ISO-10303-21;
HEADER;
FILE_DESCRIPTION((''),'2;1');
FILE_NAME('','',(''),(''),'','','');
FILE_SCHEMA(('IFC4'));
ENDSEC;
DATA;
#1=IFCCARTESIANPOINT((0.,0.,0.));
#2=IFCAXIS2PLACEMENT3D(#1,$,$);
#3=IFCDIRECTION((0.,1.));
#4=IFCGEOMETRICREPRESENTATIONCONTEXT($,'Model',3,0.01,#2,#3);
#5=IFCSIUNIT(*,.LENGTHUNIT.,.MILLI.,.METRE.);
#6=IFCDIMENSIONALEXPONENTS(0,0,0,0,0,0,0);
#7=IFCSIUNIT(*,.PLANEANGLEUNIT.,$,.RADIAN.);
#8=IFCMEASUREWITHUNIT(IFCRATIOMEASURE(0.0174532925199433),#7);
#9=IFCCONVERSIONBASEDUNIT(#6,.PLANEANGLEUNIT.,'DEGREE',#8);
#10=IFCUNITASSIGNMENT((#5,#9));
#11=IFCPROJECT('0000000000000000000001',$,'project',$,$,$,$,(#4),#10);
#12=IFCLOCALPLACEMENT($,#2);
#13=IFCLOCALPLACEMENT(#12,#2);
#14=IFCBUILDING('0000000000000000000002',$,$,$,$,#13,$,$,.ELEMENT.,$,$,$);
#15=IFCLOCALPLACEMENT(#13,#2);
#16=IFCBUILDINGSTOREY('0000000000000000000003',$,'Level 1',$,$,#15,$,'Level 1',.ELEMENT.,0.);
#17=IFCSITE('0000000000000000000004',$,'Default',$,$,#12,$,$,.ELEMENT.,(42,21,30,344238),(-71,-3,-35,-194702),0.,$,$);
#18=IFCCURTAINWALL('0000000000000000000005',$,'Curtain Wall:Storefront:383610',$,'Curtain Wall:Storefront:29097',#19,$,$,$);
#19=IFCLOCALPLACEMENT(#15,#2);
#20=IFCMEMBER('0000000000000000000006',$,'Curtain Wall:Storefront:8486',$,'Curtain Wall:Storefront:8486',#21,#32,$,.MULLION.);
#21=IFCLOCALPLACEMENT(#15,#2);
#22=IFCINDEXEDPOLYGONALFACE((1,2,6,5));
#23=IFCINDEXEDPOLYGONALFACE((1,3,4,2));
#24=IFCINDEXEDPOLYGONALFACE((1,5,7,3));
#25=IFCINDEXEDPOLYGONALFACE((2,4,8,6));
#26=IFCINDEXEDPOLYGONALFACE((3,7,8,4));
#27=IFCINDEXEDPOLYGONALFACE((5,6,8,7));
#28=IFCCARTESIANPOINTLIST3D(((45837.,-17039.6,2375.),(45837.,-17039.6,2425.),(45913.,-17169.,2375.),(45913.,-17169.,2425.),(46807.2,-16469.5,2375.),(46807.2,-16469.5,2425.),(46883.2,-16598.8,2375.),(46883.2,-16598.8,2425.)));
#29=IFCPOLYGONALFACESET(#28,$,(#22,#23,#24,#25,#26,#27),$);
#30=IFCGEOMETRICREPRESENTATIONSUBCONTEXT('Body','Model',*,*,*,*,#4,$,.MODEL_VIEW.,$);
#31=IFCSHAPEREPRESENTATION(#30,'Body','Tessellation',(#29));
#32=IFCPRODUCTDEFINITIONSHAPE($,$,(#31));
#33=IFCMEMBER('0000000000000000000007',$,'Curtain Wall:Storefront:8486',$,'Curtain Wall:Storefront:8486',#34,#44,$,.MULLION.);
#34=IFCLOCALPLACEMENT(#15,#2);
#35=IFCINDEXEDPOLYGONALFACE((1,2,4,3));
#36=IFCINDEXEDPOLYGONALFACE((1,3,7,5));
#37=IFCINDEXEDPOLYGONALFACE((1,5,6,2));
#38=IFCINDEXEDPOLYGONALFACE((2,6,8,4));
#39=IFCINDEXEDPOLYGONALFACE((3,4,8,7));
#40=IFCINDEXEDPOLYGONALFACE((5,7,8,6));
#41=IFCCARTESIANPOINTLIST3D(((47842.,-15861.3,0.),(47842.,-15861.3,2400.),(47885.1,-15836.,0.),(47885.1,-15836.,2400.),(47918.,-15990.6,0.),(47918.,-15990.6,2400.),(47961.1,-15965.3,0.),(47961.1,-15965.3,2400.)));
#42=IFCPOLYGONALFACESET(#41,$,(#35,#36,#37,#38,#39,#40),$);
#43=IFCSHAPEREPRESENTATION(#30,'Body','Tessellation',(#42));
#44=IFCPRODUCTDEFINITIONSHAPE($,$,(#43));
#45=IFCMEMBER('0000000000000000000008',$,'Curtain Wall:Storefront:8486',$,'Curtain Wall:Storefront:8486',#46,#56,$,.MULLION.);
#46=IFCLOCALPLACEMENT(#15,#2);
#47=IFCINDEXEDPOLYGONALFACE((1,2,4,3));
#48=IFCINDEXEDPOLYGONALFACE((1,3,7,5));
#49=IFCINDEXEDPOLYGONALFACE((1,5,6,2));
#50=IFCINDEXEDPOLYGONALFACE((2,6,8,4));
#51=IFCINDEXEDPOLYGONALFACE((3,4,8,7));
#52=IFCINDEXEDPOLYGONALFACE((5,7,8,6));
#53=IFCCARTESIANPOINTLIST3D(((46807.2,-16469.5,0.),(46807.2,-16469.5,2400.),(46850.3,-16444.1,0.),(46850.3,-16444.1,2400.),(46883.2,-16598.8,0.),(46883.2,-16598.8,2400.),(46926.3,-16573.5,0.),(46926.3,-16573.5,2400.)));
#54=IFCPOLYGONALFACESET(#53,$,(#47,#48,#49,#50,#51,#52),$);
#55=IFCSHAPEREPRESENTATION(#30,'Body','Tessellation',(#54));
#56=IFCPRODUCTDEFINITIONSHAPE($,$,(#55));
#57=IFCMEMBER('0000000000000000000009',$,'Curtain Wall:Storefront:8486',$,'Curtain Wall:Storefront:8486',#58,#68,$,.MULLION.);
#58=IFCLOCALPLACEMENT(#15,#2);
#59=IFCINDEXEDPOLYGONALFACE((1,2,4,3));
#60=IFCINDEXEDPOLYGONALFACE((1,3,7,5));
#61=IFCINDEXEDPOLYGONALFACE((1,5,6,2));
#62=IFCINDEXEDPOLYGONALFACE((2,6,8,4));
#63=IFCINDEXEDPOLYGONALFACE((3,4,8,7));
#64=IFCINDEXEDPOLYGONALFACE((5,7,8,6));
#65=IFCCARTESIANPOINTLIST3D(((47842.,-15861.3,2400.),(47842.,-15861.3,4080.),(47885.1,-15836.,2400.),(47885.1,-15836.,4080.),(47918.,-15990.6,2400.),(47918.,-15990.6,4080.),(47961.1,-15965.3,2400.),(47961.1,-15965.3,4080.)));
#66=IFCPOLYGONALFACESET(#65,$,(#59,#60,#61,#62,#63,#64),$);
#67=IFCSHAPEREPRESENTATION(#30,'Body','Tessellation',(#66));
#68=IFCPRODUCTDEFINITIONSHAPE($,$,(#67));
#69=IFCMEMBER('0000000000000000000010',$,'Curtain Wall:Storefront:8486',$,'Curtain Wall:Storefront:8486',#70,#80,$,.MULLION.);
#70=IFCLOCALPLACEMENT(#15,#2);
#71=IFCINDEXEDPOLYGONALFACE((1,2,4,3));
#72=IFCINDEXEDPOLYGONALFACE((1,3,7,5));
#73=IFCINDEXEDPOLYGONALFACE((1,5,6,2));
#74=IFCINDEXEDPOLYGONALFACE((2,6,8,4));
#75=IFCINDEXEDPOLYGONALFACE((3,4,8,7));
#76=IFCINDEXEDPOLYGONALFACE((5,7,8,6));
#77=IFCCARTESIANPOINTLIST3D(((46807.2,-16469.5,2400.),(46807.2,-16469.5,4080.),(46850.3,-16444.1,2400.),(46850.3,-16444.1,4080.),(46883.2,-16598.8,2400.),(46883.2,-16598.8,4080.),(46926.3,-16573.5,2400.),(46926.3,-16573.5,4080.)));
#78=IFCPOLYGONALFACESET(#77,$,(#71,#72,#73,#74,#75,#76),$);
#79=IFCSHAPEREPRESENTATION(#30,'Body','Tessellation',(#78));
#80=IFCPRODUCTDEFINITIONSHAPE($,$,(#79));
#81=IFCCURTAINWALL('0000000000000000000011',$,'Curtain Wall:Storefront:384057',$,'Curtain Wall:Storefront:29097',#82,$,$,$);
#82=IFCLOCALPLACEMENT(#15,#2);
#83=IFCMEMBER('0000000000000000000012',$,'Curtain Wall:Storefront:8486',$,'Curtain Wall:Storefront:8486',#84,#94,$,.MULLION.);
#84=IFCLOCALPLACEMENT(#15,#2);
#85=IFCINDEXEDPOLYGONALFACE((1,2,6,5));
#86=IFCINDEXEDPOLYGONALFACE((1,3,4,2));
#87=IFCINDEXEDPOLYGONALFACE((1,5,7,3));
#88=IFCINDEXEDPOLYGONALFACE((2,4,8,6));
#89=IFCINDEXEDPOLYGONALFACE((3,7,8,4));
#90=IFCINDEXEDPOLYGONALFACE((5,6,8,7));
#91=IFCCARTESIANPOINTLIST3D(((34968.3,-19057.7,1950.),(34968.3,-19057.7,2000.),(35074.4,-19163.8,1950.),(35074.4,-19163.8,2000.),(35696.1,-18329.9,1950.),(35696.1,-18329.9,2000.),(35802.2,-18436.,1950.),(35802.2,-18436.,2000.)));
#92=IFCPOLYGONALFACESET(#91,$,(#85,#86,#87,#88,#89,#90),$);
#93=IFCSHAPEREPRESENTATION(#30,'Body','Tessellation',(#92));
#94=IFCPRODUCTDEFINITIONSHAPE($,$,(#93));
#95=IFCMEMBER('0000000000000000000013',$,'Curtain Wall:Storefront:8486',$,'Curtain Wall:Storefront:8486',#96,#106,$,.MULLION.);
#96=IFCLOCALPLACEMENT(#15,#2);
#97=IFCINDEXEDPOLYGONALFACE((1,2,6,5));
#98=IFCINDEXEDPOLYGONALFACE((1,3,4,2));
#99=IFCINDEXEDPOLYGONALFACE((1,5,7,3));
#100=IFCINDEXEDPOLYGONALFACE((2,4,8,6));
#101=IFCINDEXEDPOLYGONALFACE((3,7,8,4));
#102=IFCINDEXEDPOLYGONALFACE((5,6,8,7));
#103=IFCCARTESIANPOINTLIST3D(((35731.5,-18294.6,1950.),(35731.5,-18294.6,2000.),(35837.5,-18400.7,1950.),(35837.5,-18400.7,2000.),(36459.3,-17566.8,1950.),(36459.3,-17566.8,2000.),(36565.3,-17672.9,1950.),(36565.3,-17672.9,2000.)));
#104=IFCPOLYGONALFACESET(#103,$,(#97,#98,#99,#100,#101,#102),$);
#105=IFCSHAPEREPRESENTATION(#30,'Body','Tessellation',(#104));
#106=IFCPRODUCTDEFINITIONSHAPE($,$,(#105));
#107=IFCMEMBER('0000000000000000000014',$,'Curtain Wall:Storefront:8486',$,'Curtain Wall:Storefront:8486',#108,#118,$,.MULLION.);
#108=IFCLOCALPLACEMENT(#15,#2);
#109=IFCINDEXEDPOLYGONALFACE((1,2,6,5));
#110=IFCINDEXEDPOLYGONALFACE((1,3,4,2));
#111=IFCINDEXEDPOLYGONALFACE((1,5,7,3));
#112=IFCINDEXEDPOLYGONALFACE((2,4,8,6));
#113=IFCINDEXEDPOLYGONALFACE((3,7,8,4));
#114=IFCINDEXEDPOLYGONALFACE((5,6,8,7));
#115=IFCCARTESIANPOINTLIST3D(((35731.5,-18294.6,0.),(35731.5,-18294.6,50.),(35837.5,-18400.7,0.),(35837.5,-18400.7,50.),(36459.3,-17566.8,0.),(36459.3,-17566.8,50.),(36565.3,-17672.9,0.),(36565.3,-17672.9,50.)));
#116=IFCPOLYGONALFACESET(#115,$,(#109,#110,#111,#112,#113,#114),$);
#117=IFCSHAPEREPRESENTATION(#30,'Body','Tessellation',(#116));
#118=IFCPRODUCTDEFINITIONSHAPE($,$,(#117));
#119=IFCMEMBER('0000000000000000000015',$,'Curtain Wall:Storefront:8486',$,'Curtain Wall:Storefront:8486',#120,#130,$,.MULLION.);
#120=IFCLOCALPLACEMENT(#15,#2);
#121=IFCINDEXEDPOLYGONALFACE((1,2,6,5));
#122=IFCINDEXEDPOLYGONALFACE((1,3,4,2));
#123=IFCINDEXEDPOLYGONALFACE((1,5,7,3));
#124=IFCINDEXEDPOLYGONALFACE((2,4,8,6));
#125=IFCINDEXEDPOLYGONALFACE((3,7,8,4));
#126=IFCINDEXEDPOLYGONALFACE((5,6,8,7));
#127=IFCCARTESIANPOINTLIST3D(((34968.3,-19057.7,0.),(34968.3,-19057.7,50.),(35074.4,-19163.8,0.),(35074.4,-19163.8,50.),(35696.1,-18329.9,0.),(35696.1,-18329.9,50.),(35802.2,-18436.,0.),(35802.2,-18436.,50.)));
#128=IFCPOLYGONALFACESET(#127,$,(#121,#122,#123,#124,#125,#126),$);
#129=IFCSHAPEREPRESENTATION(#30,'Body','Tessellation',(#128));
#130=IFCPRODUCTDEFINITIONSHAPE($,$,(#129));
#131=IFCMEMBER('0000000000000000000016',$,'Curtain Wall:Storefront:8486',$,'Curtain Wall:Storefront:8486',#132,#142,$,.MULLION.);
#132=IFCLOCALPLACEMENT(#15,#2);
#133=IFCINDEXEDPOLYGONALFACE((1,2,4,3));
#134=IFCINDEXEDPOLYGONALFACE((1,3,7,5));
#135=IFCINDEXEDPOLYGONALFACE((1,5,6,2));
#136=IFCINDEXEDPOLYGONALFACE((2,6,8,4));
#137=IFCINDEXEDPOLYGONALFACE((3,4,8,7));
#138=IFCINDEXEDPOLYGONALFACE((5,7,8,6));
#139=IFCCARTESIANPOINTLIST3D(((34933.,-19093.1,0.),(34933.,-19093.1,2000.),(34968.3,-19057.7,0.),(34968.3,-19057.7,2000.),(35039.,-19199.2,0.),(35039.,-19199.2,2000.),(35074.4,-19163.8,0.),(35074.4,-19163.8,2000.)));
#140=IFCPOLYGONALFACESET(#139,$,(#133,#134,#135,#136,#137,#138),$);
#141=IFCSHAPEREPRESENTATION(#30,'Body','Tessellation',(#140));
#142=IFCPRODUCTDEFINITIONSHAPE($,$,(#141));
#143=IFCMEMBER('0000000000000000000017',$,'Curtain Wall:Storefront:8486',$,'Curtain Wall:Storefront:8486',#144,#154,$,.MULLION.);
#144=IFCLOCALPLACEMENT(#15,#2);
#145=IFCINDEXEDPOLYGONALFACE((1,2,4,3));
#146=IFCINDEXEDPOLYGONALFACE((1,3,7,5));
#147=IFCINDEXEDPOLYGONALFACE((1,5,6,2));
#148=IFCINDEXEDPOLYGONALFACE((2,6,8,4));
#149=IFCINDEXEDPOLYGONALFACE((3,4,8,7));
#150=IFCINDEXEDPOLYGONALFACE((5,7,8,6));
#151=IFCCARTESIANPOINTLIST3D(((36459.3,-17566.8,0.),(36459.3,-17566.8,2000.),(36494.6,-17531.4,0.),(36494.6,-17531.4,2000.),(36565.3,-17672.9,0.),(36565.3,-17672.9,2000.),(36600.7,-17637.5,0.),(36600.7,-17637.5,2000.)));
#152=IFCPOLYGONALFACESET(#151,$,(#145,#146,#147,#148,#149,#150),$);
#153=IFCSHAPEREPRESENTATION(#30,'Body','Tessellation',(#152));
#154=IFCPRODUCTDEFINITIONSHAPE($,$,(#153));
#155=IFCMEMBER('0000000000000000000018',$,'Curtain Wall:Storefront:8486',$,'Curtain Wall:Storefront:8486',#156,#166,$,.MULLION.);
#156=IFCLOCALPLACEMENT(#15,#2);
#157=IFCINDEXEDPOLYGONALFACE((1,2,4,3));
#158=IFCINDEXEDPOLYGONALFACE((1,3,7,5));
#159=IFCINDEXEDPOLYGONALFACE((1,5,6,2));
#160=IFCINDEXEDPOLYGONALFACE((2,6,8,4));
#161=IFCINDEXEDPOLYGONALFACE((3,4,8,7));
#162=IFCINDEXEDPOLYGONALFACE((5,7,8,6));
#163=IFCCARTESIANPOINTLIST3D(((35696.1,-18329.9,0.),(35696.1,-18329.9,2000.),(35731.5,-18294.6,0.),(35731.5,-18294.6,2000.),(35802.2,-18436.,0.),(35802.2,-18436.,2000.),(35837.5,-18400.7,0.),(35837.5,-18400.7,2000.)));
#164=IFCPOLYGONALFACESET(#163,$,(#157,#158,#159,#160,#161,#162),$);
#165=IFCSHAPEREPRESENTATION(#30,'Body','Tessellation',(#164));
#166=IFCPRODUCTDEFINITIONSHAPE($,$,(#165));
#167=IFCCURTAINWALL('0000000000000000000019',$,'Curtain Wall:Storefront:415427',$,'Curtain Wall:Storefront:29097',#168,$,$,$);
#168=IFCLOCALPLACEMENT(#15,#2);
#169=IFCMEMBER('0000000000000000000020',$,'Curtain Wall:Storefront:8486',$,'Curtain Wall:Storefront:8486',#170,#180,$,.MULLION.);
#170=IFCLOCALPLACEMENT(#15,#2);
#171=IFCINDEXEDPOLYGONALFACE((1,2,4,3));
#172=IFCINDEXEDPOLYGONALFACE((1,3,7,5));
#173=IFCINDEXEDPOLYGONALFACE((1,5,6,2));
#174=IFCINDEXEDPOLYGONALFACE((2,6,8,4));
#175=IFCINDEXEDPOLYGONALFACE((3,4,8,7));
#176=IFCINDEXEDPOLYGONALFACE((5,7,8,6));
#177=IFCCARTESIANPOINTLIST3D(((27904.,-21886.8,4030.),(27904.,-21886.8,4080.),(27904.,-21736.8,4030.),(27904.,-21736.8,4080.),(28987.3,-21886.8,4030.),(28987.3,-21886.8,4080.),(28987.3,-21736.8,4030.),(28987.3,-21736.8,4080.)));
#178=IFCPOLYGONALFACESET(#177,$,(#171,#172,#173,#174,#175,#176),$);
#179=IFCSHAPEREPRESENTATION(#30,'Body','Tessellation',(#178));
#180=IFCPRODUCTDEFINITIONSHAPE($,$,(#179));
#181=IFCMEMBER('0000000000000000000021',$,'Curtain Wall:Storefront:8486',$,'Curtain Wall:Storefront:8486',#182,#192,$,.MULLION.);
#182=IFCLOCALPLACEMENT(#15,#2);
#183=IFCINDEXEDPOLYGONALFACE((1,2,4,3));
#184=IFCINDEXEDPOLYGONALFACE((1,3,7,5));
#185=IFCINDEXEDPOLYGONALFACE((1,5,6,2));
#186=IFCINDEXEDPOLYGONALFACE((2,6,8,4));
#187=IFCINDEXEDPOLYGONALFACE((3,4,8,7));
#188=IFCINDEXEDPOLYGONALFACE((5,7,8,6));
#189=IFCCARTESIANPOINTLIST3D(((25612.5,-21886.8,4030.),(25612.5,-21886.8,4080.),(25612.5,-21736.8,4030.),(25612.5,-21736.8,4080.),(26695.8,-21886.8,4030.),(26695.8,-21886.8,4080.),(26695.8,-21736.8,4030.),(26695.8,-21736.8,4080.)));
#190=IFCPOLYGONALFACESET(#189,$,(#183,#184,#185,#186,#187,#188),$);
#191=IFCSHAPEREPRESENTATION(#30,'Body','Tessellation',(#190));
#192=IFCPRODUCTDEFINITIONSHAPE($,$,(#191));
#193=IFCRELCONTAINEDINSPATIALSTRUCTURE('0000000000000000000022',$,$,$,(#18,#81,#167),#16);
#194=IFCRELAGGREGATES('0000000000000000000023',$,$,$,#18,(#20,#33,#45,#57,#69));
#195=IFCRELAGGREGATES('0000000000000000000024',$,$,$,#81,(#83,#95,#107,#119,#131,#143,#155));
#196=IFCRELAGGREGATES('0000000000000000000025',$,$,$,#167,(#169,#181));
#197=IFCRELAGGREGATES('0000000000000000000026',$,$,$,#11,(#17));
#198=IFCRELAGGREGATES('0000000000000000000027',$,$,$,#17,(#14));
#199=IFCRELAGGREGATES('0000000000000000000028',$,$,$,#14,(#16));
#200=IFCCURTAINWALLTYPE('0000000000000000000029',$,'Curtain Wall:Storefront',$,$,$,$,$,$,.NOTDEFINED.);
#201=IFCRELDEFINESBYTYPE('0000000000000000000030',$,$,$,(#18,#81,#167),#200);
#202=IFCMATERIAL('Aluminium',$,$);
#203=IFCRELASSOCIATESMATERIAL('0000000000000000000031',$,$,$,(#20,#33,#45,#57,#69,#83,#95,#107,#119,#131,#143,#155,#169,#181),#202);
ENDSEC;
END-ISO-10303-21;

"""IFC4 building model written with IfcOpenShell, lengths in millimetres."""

from ifc_helpers import new_model, entity, si_unit, converted_unit, direction, frame, frame_2d, origin, origin_2d_with_axis, place, context, subcontext, project, spatial, rectangle, extrude, material, type_object, element, aggregate, save


model = new_model("IFC4")

# Units and contexts
model_context = context("Model", 3, precision=0.01, world=origin(), true_north=direction((0.0, 1.0)))
body_context = subcontext(model_context, "Body", "Model", "MODEL_VIEW")
ifc_project = project(units=[si_unit("LENGTHUNIT", "METRE", prefix="MILLI"), converted_unit("PLANEANGLEUNIT", "DEGREE", entity("IfcRatioMeasure", 0.0174532925199433), si_unit("PLANEANGLEUNIT", "RADIAN"), dimensions=[0, 0, 0, 0, 0, 0, 0])], contexts=[model_context])

# Site, building, storey
site_placement = place(None, origin())
site = spatial("IfcSite", under=ifc_project, at=site_placement, Name="Default", CompositionType="ELEMENT", RefLatitude=(42, 21, 30, 344238), RefLongitude=(-71, -3, -35, -194702), RefElevation=0.0)
building_placement = place(site_placement, origin())
building = spatial("IfcBuilding", under=site, at=building_placement, CompositionType="ELEMENT")
storey_placement = place(building_placement, origin())
storey = spatial("IfcBuildingStorey", under=building, at=storey_placement, Name="Level 1", LongName="Level 1", CompositionType="ELEMENT", Elevation=0.0)

# Curtain walls, members
curtain_wall_type = type_object("IfcCurtainWallType", Name="Curtain Wall:Storefront", PredefinedType="NOTDEFINED")
curtain_wall_1_placement = place(storey_placement, origin())
curtain_wall_1 = element("IfcCurtainWall", 1, at=curtain_wall_1_placement, inside=storey, type_object=curtain_wall_type, Name="Curtain Wall:Storefront:383610", ObjectType="Curtain Wall:Storefront:29097")
ifc_material_1 = material(Name="Aluminium")
member_1_placement = place(curtain_wall_1_placement, origin())
member_1 = element("IfcMember", 2, at=member_1_placement, material=ifc_material_1, Name="Curtain Wall:Storefront:8486", ObjectType="Curtain Wall:Storefront:8486", PredefinedType="MULLION", context=body_context, shape_type="SweptSolid", body=[
    extrude(rectangle(XDim=50.0, YDim=150.0, at=origin_2d_with_axis()), frame((45875.0, -17104.3, 2400.0), z_axis=(0.862143, 0.506665, 0.0), x_axis=(0.0, 0.0, -1.0)), (0.0, 0.0, 1.0), 1125.3),
])
member_2_placement = place(curtain_wall_1_placement, origin())
member_2 = element("IfcMember", 3, at=member_2_placement, material=ifc_material_1, Name="Curtain Wall:Storefront:8486", ObjectType="Curtain Wall:Storefront:8486", PredefinedType="MULLION", context=body_context, shape_type="SweptSolid", body=[
    extrude(rectangle(XDim=50.0, YDim=150.0, at=frame_2d((0.0, 0.0), x_axis=(1.0, 0.0))), frame((47901.6, -15913.3, 0.0), z_axis=(0.0, 0.0, 1.0), x_axis=(0.862143, 0.506665, 0.0)), (0.0, 0.0, 1.0), 2400.0),
])
member_3_placement = place(curtain_wall_1_placement, origin())
member_3 = element("IfcMember", 4, at=member_3_placement, material=ifc_material_1, Name="Curtain Wall:Storefront:8486", ObjectType="Curtain Wall:Storefront:8486", PredefinedType="MULLION", context=body_context, shape_type="SweptSolid", body=[
    extrude(rectangle(XDim=50.0, YDim=150.0, at=frame_2d((0.0, 0.0), x_axis=(1.0, 0.0))), frame((46866.7, -16521.5, 0.0), z_axis=(0.0, 0.0, 1.0), x_axis=(0.862143, 0.506665, 0.0)), (0.0, 0.0, 1.0), 2400.0),
])
member_4_placement = place(curtain_wall_1_placement, origin())
member_4 = element("IfcMember", 5, at=member_4_placement, material=ifc_material_1, Name="Curtain Wall:Storefront:8486", ObjectType="Curtain Wall:Storefront:8486", PredefinedType="MULLION", context=body_context, shape_type="SweptSolid", body=[
    extrude(rectangle(XDim=50.0, YDim=150.0, at=frame_2d((0.0, 0.0), x_axis=(1.0, 0.0))), frame((47901.6, -15913.3, 2400.0), z_axis=(0.0, 0.0, 1.0), x_axis=(0.862143, 0.506665, 0.0)), (0.0, 0.0, 1.0), 1680.0),
])
member_5_placement = place(curtain_wall_1_placement, origin())
member_5 = element("IfcMember", 6, at=member_5_placement, material=ifc_material_1, Name="Curtain Wall:Storefront:8486", ObjectType="Curtain Wall:Storefront:8486", PredefinedType="MULLION", context=body_context, shape_type="SweptSolid", body=[
    extrude(rectangle(XDim=50.0, YDim=150.0, at=frame_2d((0.0, 0.0), x_axis=(1.0, 0.0))), frame((46866.7, -16521.5, 2400.0), z_axis=(0.0, 0.0, 1.0), x_axis=(0.862143, 0.506665, 0.0)), (0.0, 0.0, 1.0), 1680.0),
])
aggregate(curtain_wall_1, [member_1, member_2, member_3, member_4, member_5])
curtain_wall_2_placement = place(storey_placement, origin())
curtain_wall_2 = element("IfcCurtainWall", 7, at=curtain_wall_2_placement, inside=storey, type_object=curtain_wall_type, Name="Curtain Wall:Storefront:384057", ObjectType="Curtain Wall:Storefront:29097")
member_6_placement = place(curtain_wall_2_placement, origin())
member_6 = element("IfcMember", 8, at=member_6_placement, material=ifc_material_1, Name="Curtain Wall:Storefront:8486", ObjectType="Curtain Wall:Storefront:8486", PredefinedType="MULLION", context=body_context, shape_type="SweptSolid", body=[
    extrude(rectangle(XDim=50.0, YDim=150.0, at=origin_2d_with_axis()), frame((35021.4, -19110.8, 1975.0), z_axis=(0.707107, 0.707107, 0.0), x_axis=(0.0, 0.0, -1.0)), (0.0, 0.0, 1.0), 1029.3),
])
member_7_placement = place(curtain_wall_2_placement, origin())
member_7 = element("IfcMember", 9, at=member_7_placement, material=ifc_material_1, Name="Curtain Wall:Storefront:8486", ObjectType="Curtain Wall:Storefront:8486", PredefinedType="MULLION", context=body_context, shape_type="SweptSolid", body=[
    extrude(rectangle(XDim=50.0, YDim=150.0, at=frame_2d((0.0, 0.0), x_axis=(1.0, 0.0))), frame((35784.5, -18347.6, 1975.0), z_axis=(0.707107, 0.707107, 0.0), x_axis=(0.0, 0.0, -1.0)), (0.0, 0.0, 1.0), 1029.3),
])
member_8_placement = place(curtain_wall_2_placement, origin())
member_8 = element("IfcMember", 10, at=member_8_placement, material=ifc_material_1, Name="Curtain Wall:Storefront:8486", ObjectType="Curtain Wall:Storefront:8486", PredefinedType="MULLION", context=body_context, shape_type="SweptSolid", body=[
    extrude(rectangle(XDim=50.0, YDim=150.0, at=frame_2d((0.0, 0.0), x_axis=(1.0, 0.0))), frame((36512.3, -17619.8, 25.0), z_axis=(-0.707107, -0.707107, 0.0), x_axis=(0.0, 0.0, -1.0)), (0.0, 0.0, 1.0), 1029.3),
])
member_9_placement = place(curtain_wall_2_placement, origin())
member_9 = element("IfcMember", 11, at=member_9_placement, material=ifc_material_1, Name="Curtain Wall:Storefront:8486", ObjectType="Curtain Wall:Storefront:8486", PredefinedType="MULLION", context=body_context, shape_type="SweptSolid", body=[
    extrude(rectangle(XDim=50.0, YDim=150.0, at=frame_2d((0.0, 0.0), x_axis=(1.0, 0.0))), frame((35749.1, -18383.0, 25.0), z_axis=(-0.707107, -0.707107, 0.0), x_axis=(0.0, 0.0, -1.0)), (0.0, 0.0, 1.0), 1029.3),
])
member_10_placement = place(curtain_wall_2_placement, origin())
member_10 = element("IfcMember", 12, at=member_10_placement, material=ifc_material_1, Name="Curtain Wall:Storefront:8486", ObjectType="Curtain Wall:Storefront:8486", PredefinedType="MULLION", context=body_context, shape_type="SweptSolid", body=[
    extrude(rectangle(XDim=150.0, YDim=50.0, at=frame_2d((0.0, 0.0), x_axis=(1.0, 0.0))), frame((35003.7, -19128.4, 0.0), z_axis=(0.0, 0.0, 1.0), x_axis=(0.707107, -0.707107, 0.0)), (0.0, 0.0, 1.0), 2000.0),
])
member_11_placement = place(curtain_wall_2_placement, origin())
member_11 = element("IfcMember", 13, at=member_11_placement, material=ifc_material_1, Name="Curtain Wall:Storefront:8486", ObjectType="Curtain Wall:Storefront:8486", PredefinedType="MULLION", context=body_context, shape_type="SweptSolid", body=[
    extrude(rectangle(XDim=50.0, YDim=150.0, at=frame_2d((0.0, 0.0), x_axis=(1.0, 0.0))), frame((36530.0, -17602.1, 2000.0), z_axis=(0.0, 0.0, -1.0), x_axis=(0.707107, 0.707107, 0.0)), (0.0, 0.0, 1.0), 2000.0),
])
member_12_placement = place(curtain_wall_2_placement, origin())
member_12 = element("IfcMember", 14, at=member_12_placement, material=ifc_material_1, Name="Curtain Wall:Storefront:8486", ObjectType="Curtain Wall:Storefront:8486", PredefinedType="MULLION", context=body_context, shape_type="SweptSolid", body=[
    extrude(rectangle(XDim=150.0, YDim=50.0, at=origin_2d_with_axis()), frame((35766.8, -18365.3, 0.0), z_axis=(0.0, 0.0, 1.0), x_axis=(0.707107, -0.707107, 0.0)), (0.0, 0.0, 1.0), 2000.0),
])
aggregate(curtain_wall_2, [member_6, member_7, member_8, member_9, member_10, member_11, member_12])
curtain_wall_3_placement = place(storey_placement, origin())
curtain_wall_3 = element("IfcCurtainWall", 15, at=curtain_wall_3_placement, inside=storey, type_object=curtain_wall_type, Name="Curtain Wall:Storefront:415427", ObjectType="Curtain Wall:Storefront:29097")
member_13_placement = place(curtain_wall_3_placement, origin())
member_13 = element("IfcMember", 16, at=member_13_placement, material=ifc_material_1, Name="Curtain Wall:Storefront:8486", ObjectType="Curtain Wall:Storefront:8486", PredefinedType="MULLION", context=body_context, shape_type="SweptSolid", body=[
    extrude(rectangle(XDim=50.0, YDim=150.0, at=frame_2d((0.0, 0.0), x_axis=(1.0, 0.0))), frame((28987.3, -21811.8, 4055.0), z_axis=(-1.0, 0.0, 0.0), x_axis=(0.0, 0.0, -1.0)), (0.0, 0.0, 1.0), 1083.3),
])
member_14_placement = place(curtain_wall_3_placement, origin())
member_14 = element("IfcMember", 17, at=member_14_placement, material=ifc_material_1, Name="Curtain Wall:Storefront:8486", ObjectType="Curtain Wall:Storefront:8486", PredefinedType="MULLION", context=body_context, shape_type="SweptSolid", body=[
    extrude(rectangle(XDim=50.0, YDim=150.0, at=frame_2d((0.0, 0.0), x_axis=(1.0, 0.0))), frame((26695.8, -21811.8, 4055.0), z_axis=(-1.0, 0.0, 0.0), x_axis=(0.0, 0.0, -1.0)), (0.0, 0.0, 1.0), 1083.3),
])
aggregate(curtain_wall_3, [member_13, member_14])

save(model, "model.ifc")
